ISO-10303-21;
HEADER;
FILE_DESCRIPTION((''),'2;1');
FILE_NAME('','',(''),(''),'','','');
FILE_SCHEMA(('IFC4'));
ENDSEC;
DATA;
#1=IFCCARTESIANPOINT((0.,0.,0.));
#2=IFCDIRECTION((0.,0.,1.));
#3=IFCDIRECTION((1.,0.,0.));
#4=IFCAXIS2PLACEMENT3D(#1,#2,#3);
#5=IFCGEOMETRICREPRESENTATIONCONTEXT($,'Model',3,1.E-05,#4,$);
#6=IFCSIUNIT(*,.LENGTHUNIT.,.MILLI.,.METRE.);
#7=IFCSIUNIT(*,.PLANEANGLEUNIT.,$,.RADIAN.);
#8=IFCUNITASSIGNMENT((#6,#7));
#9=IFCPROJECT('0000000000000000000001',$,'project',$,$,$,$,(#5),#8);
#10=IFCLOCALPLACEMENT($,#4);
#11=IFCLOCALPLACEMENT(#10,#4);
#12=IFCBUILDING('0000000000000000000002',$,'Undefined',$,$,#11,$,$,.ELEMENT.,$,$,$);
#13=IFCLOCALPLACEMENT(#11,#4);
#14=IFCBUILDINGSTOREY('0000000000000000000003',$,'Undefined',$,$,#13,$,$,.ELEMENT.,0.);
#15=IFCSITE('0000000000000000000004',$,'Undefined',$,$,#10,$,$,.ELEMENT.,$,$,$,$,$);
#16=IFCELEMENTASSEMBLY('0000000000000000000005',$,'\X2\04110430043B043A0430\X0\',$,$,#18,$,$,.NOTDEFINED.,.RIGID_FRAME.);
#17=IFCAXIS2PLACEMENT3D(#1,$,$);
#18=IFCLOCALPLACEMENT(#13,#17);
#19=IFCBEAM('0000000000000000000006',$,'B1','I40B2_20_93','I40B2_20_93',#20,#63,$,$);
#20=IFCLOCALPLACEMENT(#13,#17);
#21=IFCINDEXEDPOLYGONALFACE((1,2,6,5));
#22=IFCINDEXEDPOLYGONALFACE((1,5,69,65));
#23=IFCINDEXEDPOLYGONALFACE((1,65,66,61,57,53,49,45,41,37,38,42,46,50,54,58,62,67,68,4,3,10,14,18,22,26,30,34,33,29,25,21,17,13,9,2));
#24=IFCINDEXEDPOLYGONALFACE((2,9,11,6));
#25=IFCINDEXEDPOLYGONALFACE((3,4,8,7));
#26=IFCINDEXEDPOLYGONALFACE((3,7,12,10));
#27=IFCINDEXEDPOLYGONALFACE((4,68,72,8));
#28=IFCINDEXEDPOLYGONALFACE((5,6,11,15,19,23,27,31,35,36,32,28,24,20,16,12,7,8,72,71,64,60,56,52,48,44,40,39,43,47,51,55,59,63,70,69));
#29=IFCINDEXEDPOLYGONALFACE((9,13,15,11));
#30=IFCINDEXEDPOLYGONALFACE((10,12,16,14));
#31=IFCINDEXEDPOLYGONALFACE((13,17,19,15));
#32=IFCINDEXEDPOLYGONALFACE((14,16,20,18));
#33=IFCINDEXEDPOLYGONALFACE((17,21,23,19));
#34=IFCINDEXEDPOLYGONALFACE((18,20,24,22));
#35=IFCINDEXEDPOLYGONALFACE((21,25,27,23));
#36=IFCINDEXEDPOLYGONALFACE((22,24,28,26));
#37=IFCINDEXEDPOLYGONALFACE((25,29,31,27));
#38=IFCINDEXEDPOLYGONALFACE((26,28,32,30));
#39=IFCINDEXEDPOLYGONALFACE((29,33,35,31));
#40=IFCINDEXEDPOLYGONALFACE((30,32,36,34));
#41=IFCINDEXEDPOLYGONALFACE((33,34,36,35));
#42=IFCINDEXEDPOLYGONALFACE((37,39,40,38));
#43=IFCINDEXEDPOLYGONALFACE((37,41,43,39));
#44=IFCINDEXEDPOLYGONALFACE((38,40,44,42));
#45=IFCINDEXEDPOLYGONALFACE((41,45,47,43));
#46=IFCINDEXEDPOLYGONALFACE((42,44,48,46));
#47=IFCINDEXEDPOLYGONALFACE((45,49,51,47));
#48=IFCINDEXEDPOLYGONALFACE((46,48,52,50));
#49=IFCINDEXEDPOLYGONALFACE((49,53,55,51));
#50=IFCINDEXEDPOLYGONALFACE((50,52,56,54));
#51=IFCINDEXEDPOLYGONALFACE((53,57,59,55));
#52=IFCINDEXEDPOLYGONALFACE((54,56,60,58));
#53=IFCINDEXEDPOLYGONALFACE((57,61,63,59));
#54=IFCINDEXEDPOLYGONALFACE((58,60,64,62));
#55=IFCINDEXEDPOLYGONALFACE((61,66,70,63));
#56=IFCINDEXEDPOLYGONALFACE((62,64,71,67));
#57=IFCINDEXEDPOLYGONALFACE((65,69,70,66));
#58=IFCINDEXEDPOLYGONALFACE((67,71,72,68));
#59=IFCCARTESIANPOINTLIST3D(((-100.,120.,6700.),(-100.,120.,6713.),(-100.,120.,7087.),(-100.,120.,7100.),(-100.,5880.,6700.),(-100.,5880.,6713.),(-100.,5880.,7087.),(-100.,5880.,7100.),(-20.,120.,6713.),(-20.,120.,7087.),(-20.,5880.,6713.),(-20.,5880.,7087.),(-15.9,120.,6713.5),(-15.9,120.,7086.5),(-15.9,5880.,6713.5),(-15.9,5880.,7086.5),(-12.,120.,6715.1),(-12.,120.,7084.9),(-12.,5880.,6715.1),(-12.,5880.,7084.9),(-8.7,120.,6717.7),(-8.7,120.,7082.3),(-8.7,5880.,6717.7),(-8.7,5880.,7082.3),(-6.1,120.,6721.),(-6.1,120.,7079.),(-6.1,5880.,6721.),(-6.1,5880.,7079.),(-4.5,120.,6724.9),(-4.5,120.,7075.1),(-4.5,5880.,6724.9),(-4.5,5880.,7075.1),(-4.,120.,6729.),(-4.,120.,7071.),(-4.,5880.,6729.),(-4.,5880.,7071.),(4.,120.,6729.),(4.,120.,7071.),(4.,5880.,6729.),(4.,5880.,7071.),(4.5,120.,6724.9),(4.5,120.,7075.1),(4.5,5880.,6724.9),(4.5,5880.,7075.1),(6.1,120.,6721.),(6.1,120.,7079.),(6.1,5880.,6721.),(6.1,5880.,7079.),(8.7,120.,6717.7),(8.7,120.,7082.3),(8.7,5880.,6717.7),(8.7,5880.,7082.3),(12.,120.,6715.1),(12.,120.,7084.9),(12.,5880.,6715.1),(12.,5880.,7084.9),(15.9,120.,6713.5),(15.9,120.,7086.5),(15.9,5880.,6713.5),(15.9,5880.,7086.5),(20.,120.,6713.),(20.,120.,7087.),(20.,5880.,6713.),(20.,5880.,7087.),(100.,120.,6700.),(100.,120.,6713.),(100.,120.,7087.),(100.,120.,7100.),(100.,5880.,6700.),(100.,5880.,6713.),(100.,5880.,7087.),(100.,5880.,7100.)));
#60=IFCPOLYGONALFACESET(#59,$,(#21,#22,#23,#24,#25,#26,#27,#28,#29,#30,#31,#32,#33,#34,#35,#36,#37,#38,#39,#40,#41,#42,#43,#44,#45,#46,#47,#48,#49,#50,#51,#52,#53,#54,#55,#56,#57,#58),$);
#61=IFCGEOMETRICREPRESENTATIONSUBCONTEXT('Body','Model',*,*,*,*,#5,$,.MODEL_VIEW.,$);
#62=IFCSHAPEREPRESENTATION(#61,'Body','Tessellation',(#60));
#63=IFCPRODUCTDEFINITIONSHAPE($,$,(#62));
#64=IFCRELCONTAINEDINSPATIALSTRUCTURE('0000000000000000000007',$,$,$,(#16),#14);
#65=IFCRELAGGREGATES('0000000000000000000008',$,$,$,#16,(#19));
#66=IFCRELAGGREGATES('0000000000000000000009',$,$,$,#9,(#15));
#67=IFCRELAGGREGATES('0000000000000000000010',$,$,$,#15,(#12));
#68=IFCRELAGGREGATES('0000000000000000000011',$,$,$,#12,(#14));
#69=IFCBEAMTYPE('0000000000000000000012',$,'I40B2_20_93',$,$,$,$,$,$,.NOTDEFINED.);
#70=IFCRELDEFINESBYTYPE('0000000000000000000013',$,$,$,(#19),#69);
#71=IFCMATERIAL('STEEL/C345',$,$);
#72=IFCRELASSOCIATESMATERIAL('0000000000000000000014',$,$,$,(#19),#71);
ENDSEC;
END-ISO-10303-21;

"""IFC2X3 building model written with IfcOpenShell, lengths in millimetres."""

from ifc_helpers import new_model, si_unit, frame, origin_with_axes, origin_2d_with_axis, place, context, subcontext, project, spatial, i_section, extrude, material, type_object, element, aggregate, save


model = new_model("IFC2X3")

# Units and contexts
model_context = context("Model", 3, precision=1e-05, world=origin_with_axes())
body_context = subcontext(model_context, "Body", "Model", "MODEL_VIEW")
ifc_project = project(units=[si_unit("LENGTHUNIT", "METRE", prefix="MILLI"), si_unit("PLANEANGLEUNIT", "RADIAN")], contexts=[model_context])

# Site, building, storey
site_placement = place(None, origin_with_axes())
site = spatial("IfcSite", under=ifc_project, at=site_placement, Name="Undefined", CompositionType="ELEMENT")
building_placement = place(site_placement, origin_with_axes())
building = spatial("IfcBuilding", under=site, at=building_placement, Name="Undefined", CompositionType="ELEMENT")
storey_placement = place(building_placement, origin_with_axes())
storey = spatial("IfcBuildingStorey", under=building, at=storey_placement, Name="Undefined", CompositionType="ELEMENT", Elevation=0.0)

# Element assembly, beam
ifc_material_1 = material(Name="STEEL/C345")
beam_type_1 = type_object("IfcBeamType", Name="I40B2_20_93", PredefinedType="NOTDEFINED")
assembly_1_placement = place(storey_placement, origin_with_axes())
assembly_1 = element("IfcElementAssembly", 1, at=assembly_1_placement, inside=storey, Name="Балка", AssemblyPlace="NOTDEFINED", PredefinedType="RIGID_FRAME")
beam_1_placement = place(assembly_1_placement, frame((0.0, 120.0, 6900.0), z_axis=(0.0, 0.0, 1.0), x_axis=(0.0, 1.0, 0.0)))
beam_1 = element("IfcBeam", 2, at=beam_1_placement, type_object=beam_type_1, material=ifc_material_1, Name="B1", Description="I40B2_20_93", ObjectType="I40B2_20_93", context=body_context, shape_type="SweptSolid", body=[
    extrude(i_section(OverallWidth=200.0, OverallDepth=400.0, WebThickness=8.0, FlangeThickness=13.0, FilletRadius=16.0, at=origin_2d_with_axis()), frame((5760.0, 0.0, 0.0), z_axis=(-1.0, 0.0, 0.0), x_axis=(0.0, -1.0, 0.0)), (0.0, 0.0, 1.0), 5760.0),
])
aggregate(assembly_1, [beam_1])

save(model, "model.ifc")
